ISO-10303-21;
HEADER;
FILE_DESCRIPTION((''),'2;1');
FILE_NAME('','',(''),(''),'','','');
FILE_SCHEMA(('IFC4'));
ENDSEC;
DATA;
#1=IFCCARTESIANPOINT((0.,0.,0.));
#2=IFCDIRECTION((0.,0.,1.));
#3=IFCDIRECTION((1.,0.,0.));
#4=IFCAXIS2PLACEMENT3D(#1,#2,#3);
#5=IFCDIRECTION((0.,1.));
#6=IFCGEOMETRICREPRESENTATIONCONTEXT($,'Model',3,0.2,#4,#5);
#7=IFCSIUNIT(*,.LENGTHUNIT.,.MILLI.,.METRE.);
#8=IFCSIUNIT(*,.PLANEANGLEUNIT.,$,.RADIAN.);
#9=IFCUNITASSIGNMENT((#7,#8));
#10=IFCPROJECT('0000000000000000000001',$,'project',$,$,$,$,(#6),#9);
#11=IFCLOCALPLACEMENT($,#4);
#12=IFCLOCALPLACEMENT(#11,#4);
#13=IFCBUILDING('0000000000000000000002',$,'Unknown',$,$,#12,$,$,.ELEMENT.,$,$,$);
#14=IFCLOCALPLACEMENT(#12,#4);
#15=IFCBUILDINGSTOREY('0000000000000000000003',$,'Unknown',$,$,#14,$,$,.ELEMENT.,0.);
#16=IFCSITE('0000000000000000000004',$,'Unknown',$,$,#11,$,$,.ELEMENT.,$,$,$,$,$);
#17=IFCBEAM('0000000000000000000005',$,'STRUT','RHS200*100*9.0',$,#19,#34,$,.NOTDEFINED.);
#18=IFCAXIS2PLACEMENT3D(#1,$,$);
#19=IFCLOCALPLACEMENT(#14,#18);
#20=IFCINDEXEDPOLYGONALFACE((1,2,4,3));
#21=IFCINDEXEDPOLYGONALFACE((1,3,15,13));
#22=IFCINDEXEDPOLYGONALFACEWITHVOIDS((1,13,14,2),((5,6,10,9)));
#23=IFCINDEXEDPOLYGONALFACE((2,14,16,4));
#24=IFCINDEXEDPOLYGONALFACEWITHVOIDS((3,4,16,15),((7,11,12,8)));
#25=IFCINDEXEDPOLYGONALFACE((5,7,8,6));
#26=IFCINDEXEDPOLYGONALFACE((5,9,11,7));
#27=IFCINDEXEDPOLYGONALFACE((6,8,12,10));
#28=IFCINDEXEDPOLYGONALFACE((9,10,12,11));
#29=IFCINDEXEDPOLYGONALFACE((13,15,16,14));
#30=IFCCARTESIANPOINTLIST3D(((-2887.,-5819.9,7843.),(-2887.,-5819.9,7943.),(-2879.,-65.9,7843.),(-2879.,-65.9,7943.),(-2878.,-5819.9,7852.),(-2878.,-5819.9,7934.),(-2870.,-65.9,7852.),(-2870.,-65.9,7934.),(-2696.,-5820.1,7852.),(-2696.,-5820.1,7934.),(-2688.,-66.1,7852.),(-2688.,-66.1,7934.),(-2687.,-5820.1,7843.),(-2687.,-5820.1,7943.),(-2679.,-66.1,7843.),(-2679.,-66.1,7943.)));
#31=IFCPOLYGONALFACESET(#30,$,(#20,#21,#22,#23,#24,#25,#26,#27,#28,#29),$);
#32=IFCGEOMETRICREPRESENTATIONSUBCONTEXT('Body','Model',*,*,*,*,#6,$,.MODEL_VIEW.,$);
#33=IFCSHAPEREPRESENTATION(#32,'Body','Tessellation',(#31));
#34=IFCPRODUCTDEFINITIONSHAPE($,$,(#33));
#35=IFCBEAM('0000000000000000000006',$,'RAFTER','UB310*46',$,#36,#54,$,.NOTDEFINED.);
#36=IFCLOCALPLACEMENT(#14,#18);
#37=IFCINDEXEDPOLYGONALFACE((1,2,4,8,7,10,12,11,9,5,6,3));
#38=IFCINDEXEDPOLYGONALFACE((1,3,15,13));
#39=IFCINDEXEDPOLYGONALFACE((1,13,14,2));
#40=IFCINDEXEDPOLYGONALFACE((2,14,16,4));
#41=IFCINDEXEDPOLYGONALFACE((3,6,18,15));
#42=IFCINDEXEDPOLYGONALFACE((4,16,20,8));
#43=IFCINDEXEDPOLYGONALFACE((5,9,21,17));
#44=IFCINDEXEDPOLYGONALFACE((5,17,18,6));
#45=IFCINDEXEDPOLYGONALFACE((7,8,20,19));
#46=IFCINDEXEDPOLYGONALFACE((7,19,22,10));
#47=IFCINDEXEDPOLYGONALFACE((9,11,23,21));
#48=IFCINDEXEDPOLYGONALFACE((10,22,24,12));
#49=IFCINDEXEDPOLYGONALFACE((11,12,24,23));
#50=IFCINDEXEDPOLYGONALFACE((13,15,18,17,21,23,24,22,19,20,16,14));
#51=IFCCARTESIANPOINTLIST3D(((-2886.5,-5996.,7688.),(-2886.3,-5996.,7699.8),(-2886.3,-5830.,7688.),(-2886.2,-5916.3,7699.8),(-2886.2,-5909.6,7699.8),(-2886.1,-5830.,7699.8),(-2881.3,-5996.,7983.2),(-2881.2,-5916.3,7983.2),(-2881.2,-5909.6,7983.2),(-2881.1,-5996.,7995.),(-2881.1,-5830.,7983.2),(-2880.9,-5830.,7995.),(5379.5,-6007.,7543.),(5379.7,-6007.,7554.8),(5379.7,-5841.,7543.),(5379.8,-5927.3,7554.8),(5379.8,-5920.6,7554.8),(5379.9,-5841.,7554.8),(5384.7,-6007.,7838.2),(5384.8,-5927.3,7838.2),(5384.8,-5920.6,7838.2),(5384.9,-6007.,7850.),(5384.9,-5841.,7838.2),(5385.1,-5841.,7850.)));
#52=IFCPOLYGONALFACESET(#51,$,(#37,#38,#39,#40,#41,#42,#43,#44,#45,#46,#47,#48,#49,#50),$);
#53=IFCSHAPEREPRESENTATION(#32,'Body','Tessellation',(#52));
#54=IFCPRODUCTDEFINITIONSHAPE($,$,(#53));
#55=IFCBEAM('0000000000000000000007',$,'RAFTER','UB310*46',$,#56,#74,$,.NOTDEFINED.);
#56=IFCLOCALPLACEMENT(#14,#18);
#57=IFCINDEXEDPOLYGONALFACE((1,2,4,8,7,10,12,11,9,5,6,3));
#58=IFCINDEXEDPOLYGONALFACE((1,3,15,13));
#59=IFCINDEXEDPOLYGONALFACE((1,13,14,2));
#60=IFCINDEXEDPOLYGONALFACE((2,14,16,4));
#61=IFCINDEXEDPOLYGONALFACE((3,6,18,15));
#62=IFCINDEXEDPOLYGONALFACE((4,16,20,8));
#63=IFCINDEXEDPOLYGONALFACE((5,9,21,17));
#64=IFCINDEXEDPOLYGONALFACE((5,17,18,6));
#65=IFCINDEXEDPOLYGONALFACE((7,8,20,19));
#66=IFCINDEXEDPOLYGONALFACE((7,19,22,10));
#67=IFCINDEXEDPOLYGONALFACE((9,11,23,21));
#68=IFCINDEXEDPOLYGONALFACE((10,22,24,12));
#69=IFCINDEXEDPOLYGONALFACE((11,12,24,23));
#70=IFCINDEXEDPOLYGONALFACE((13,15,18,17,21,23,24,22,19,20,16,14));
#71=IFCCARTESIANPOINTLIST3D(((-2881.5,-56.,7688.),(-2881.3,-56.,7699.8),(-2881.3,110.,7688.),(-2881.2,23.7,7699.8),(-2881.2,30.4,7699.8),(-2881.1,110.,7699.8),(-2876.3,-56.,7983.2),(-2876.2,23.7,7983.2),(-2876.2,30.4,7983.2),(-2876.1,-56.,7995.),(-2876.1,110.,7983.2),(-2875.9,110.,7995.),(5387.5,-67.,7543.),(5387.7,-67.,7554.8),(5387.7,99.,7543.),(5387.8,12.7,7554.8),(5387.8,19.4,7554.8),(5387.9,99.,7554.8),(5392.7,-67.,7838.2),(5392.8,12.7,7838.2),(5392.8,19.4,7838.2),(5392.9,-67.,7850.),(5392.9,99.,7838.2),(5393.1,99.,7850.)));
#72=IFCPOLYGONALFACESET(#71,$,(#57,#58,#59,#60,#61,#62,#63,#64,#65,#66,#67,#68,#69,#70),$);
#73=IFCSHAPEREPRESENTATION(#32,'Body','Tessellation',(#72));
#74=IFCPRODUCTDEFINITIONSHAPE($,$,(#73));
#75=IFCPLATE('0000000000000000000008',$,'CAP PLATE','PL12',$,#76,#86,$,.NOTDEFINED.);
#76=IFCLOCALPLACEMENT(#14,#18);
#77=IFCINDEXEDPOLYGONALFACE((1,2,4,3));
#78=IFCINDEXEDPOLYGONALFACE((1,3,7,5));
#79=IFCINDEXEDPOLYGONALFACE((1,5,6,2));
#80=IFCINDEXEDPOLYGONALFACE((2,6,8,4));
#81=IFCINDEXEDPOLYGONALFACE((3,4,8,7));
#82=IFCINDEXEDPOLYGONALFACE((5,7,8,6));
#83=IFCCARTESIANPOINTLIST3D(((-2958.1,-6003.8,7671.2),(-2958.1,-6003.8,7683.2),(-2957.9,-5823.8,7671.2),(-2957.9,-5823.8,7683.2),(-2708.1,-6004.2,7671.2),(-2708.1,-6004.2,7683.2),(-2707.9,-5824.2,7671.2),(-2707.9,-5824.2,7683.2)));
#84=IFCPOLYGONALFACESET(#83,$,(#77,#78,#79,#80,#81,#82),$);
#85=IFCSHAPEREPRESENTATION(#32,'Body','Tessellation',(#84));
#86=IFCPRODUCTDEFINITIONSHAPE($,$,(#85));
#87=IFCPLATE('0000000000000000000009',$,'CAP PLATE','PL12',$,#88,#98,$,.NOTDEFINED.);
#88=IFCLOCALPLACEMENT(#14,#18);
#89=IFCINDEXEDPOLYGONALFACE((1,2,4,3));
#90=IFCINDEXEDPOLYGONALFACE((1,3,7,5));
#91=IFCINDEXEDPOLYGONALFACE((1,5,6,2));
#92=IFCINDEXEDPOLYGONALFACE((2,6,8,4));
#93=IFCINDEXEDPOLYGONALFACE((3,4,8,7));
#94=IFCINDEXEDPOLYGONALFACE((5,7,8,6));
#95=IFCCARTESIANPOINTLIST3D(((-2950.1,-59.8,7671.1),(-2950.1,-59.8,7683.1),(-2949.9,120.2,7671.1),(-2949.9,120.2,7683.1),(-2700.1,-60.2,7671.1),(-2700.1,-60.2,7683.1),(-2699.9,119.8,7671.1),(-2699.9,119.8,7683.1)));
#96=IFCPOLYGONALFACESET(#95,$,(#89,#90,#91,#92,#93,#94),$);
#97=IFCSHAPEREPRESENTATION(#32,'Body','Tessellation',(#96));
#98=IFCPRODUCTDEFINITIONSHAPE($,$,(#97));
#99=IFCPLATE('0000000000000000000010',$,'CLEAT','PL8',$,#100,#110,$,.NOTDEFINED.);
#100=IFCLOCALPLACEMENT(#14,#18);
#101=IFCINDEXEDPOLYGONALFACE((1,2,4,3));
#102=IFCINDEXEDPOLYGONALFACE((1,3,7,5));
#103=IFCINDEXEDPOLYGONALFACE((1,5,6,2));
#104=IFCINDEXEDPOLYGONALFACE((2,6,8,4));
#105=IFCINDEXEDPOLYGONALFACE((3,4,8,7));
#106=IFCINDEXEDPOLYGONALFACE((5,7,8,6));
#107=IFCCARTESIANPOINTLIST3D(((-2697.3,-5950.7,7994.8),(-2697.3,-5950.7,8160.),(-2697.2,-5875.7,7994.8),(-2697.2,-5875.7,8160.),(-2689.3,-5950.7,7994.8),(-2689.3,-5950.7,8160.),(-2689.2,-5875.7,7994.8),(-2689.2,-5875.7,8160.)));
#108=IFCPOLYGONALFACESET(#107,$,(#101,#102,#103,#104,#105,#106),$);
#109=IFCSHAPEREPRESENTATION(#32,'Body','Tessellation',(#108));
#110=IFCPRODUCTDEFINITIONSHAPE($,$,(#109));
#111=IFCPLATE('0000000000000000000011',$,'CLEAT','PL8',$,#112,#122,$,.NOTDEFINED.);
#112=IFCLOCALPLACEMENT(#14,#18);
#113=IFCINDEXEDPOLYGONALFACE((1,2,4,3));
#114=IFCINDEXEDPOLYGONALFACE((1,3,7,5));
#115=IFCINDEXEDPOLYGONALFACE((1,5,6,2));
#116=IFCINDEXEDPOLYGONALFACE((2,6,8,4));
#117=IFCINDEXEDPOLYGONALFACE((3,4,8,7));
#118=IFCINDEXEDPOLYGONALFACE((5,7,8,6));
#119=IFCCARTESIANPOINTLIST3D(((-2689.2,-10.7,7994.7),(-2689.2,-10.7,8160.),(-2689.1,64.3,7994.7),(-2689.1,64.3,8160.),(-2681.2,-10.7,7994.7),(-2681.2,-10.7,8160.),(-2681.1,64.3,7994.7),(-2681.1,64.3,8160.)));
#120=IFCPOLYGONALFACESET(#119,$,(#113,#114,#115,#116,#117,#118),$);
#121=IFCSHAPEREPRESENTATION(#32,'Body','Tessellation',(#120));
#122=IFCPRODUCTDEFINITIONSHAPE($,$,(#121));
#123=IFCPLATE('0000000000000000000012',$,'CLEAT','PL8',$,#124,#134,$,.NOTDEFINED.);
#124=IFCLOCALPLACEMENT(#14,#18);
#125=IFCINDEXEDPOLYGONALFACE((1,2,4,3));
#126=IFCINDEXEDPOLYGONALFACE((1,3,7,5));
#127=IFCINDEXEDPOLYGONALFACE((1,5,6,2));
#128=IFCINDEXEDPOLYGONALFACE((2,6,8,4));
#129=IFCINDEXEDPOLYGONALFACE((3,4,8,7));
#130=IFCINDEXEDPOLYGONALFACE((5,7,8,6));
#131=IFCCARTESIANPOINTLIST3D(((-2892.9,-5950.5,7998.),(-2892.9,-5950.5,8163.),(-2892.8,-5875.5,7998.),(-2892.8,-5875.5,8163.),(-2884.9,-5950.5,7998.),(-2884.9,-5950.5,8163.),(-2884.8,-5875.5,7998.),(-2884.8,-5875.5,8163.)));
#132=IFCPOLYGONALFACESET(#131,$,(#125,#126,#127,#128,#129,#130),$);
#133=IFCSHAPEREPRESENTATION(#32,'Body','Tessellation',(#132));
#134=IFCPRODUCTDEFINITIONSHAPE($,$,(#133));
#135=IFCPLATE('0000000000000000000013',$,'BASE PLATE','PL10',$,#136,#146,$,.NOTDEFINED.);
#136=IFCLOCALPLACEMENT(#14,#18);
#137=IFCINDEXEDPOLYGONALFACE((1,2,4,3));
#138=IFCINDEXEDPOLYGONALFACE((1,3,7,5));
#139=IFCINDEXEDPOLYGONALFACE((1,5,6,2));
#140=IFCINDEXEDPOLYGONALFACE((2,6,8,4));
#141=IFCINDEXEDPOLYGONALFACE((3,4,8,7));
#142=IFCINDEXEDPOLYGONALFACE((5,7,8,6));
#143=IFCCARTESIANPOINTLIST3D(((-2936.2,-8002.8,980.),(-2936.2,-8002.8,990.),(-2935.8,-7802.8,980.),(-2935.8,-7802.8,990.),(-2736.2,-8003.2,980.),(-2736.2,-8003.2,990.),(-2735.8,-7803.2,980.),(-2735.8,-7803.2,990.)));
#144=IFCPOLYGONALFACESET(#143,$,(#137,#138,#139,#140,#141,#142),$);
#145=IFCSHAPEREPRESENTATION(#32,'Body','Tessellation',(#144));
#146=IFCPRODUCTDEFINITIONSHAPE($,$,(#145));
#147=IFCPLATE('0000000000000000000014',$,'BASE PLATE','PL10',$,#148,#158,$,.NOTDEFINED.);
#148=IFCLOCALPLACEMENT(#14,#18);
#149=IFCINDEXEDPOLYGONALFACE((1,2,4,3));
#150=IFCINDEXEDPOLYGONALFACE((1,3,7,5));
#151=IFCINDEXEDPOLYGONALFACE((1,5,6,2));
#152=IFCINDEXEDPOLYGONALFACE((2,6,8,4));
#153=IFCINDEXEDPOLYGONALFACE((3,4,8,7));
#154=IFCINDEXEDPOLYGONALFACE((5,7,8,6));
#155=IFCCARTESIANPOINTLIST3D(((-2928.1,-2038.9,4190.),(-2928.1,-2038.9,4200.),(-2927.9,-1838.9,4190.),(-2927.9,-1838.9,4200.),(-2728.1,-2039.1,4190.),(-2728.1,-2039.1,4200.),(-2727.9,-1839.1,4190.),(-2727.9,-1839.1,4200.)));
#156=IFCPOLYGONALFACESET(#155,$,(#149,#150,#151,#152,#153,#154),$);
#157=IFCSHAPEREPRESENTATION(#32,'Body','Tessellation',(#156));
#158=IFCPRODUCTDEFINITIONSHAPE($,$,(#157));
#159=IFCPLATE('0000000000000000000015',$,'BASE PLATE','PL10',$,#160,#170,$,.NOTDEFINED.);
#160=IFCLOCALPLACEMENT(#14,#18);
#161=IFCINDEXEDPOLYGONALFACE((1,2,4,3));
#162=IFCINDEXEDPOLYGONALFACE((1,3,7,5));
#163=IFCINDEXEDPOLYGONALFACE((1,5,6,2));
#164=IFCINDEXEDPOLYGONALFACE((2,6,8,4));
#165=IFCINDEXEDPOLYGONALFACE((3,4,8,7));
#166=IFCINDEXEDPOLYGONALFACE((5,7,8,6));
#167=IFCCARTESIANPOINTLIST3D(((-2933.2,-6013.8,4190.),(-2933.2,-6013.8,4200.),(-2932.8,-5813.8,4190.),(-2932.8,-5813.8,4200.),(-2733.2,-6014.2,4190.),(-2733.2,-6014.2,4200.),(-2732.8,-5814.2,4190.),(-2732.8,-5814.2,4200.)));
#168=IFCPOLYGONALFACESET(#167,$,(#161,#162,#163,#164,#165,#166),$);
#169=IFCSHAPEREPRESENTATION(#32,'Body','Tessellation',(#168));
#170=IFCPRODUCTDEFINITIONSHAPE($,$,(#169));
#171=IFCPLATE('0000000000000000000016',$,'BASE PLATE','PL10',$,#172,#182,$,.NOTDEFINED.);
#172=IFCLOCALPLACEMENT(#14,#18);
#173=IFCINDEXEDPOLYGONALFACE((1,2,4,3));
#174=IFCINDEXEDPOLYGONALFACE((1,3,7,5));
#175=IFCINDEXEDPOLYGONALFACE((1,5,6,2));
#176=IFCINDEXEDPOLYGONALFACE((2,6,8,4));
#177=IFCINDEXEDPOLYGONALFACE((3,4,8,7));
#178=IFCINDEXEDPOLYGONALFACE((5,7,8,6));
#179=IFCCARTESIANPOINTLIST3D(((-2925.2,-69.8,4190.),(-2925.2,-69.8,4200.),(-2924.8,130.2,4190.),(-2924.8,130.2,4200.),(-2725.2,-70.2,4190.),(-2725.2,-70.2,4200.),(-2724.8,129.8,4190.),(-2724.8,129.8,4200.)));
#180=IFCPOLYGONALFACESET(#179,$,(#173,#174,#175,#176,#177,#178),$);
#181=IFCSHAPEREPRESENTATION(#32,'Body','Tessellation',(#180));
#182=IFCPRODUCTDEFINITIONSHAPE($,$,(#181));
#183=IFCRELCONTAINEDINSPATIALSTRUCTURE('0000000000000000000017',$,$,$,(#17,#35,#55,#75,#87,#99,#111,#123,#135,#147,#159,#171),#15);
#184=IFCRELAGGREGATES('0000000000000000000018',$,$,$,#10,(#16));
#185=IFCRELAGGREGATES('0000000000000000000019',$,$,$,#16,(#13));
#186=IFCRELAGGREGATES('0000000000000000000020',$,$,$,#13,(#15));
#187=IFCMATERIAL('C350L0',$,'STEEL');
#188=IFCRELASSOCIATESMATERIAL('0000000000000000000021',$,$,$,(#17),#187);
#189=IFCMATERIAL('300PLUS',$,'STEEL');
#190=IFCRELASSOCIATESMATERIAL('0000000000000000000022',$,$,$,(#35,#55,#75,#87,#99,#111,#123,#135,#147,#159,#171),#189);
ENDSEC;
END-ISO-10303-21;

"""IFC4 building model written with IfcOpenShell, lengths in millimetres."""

from ifc_helpers import new_model, si_unit, direction, frame, origin_with_axes, place, context, subcontext, project, spatial, line, indexed_curve, outline, extrude, material, element, save


model = new_model("IFC4")

# Units and contexts
model_context = context("Model", 3, precision=0.2, world=origin_with_axes(), true_north=direction((0.0, 1.0)))
body_context = subcontext(model_context, "Body", "Model", "MODEL_VIEW")
ifc_project = project(units=[si_unit("LENGTHUNIT", "METRE", prefix="MILLI"), si_unit("PLANEANGLEUNIT", "RADIAN")], contexts=[model_context])

# Site, building, storey
site_placement = place(None, origin_with_axes())
site = spatial("IfcSite", under=ifc_project, at=site_placement, Name="Unknown", CompositionType="ELEMENT")
building_placement = place(site_placement, origin_with_axes())
building = spatial("IfcBuilding", under=site, at=building_placement, Name="Unknown", CompositionType="ELEMENT")
storey_placement = place(building_placement, origin_with_axes())
storey = spatial("IfcBuildingStorey", under=building, at=storey_placement, Name="Unknown", CompositionType="ELEMENT", Elevation=0.0)

# Shared definitions
ifc_material_1 = material(Name="C350L0", Category="STEEL")

# Beams
beam_1_placement = place(storey_placement, frame((-2779.0, -66.0, 7893.0), z_axis=(0.0, 0.0, 1.0), x_axis=(-0.00139, -0.999999, 0.0)))
element("IfcBeam", 1, at=beam_1_placement, inside=storey, material=ifc_material_1, Name="STRUT", Description="RHS200*100*9.0", PredefinedType="NOTDEFINED", context=body_context, shape_type="SolidModel", body=[
    extrude(outline(indexed_curve([(-50.0, -100.0), (50.0, -100.0), (50.0, 100.0), (-50.0, 100.0)], segments=[line(1, 2, 3, 4, 1)]), holes=[indexed_curve([(-41.0, -91.0), (-41.0, 91.0), (41.0, 91.0), (41.0, -91.0)], segments=[line(1, 2, 3, 4, 1)])]), frame((0.0, 0.0, 0.0), z_axis=(-1.0, 0.0, 0.0), x_axis=(0.0, 0.0, 1.0)), (0.0, 0.0, -1.0), 5754.0),
])
ifc_material_2 = material(Name="300PLUS", Category="STEEL")
beam_2_placement = place(storey_placement, frame((-2883.7, -5913.0, 7841.5), z_axis=(-0.001331, -0.999999, 0.0), x_axis=(0.999845, -0.001331, -0.017539)))
element("IfcBeam", 2, at=beam_2_placement, inside=storey, material=ifc_material_2, Name="RAFTER", Description="UB310*46", PredefinedType="NOTDEFINED", context=body_context, shape_type="SolidModel", body=[
    extrude(outline(indexed_curve([(-83.0, -153.5), (83.0, -153.5), (83.0, -141.7), (3.4, -141.7), (3.4, 141.7), (83.0, 141.7), (83.0, 153.5), (-83.0, 153.5), (-83.0, 141.7), (-3.4, 141.7), (-3.4, -141.7), (-83.0, -141.7)], segments=[line(1, 2, 3, 4, 5, 6, 7, 8, 9, 10, 11, 12, 1)])), frame((0.0, 0.0, 0.0), z_axis=(-1.0, 0.0, 0.0), x_axis=(0.0, 0.0, 1.0)), (0.0, 0.0, -1.0), 8267.3),
])
beam_3_placement = place(storey_placement, frame((-2878.7, 27.0, 7841.5), z_axis=(-0.00133, -0.999999, 0.0), x_axis=(0.999845, -0.00133, -0.017533)))
element("IfcBeam", 3, at=beam_3_placement, inside=storey, material=ifc_material_2, Name="RAFTER", Description="UB310*46", PredefinedType="NOTDEFINED", context=body_context, shape_type="SolidModel", body=[
    extrude(outline(indexed_curve([(-83.0, -153.5), (83.0, -153.5), (83.0, -141.7), (3.4, -141.7), (3.4, 141.7), (83.0, 141.7), (83.0, 153.5), (-83.0, 153.5), (-83.0, 141.7), (-3.4, 141.7), (-3.4, -141.7), (-83.0, -141.7)], segments=[line(1, 2, 3, 4, 5, 6, 7, 8, 9, 10, 11, 12, 1)])), frame((0.0, 0.0, 0.0), z_axis=(-1.0, 0.0, 0.0), x_axis=(0.0, 0.0, 1.0)), (0.0, 0.0, -1.0), 8270.3),
])

# Plates
for number, where, z_axis, x_axis, name in (
    (4, (-2958.1, -6003.8, 7677.2), (0.0, 0.0, 1.0), (0.999999, -0.0016, 0.0), "CAP PLATE"),
    (5, (-2950.1, -59.8, 7677.1), (0.0, 0.0, 1.0), (0.999999, -0.0016, 0.0), "CAP PLATE"),
):
    element("IfcPlate", number, at=place(storey_placement, frame(where, z_axis=z_axis, x_axis=x_axis)), inside=storey, material=ifc_material_2, Name=name, Description="PL12", PredefinedType="NOTDEFINED", context=body_context, shape_type="SolidModel", body=[
        extrude(outline(indexed_curve([(0.0, 0.0), (250.0, 0.0), (249.9, 180.0), (-0.1, 180.0)], segments=[line(1, 2, 3, 4, 1)])), frame((0.0, 0.0, 6.0), z_axis=(0.0, 0.0, 1.0), x_axis=(1.0, 0.0, 0.0)), (0.0, 0.0, -1.0), 12.0),
    ])
plate_1_placement = place(storey_placement, frame((-2693.2, -5875.7, 8160.0), z_axis=(0.999999, -0.001333, 0.0), x_axis=(-0.001333, -0.999999, 0.0)))
element("IfcPlate", 6, at=plate_1_placement, inside=storey, material=ifc_material_2, Name="CLEAT", Description="PL8", PredefinedType="NOTDEFINED", context=body_context, shape_type="SolidModel", body=[
    extrude(outline(indexed_curve([(0.0, 0.0), (75.0, 0.0), (75.0, 165.2), (0.0, 165.2)], segments=[line(1, 2, 3, 4, 1)])), frame((0.0, 0.0, 4.0), z_axis=(0.0, 0.0, 1.0), x_axis=(1.0, 0.0, 0.0)), (0.0, 0.0, -1.0), 8.0),
])
plate_2_placement = place(storey_placement, frame((-2685.1, 64.3, 8160.0), z_axis=(0.999999, -0.001333, 0.0), x_axis=(-0.001333, -0.999999, 0.0)))
element("IfcPlate", 7, at=plate_2_placement, inside=storey, material=ifc_material_2, Name="CLEAT", Description="PL8", PredefinedType="NOTDEFINED", context=body_context, shape_type="SolidModel", body=[
    extrude(outline(indexed_curve([(0.0, 0.0), (75.0, 0.0), (75.0, 165.3), (0.0, 165.3)], segments=[line(1, 2, 3, 4, 1)])), frame((0.0, 0.0, 4.0), z_axis=(0.0, 0.0, 1.0), x_axis=(1.0, 0.0, 0.0)), (0.0, 0.0, -1.0), 8.0),
])
plate_3_placement = place(storey_placement, frame((-2888.8, -5875.5, 8163.0), z_axis=(0.999999, -0.001333, 0.0), x_axis=(-0.001333, -0.999999, 0.0)))
element("IfcPlate", 8, at=plate_3_placement, inside=storey, material=ifc_material_2, Name="CLEAT", Description="PL8", PredefinedType="NOTDEFINED", context=body_context, shape_type="SolidModel", body=[
    extrude(outline(indexed_curve([(0.0, 0.0), (75.0, 0.0), (75.0, 165.0), (0.0, 165.0)], segments=[line(1, 2, 3, 4, 1)])), frame((0.0, 0.0, 4.0), z_axis=(0.0, 0.0, 1.0), x_axis=(1.0, 0.0, 0.0)), (0.0, 0.0, -1.0), 8.0),
])
plate_4_placement = place(storey_placement, frame((-2935.8, -7802.8, 985.0), z_axis=(0.0, 0.0, 1.0), x_axis=(-0.002, -0.999998, 0.0)))
element("IfcPlate", 9, at=plate_4_placement, inside=storey, material=ifc_material_2, Name="BASE PLATE", Description="PL10", PredefinedType="NOTDEFINED", context=body_context, shape_type="SolidModel", body=[
    extrude(outline(indexed_curve([(0.0, 0.0), (200.0, 0.0), (200.0, 200.0), (0.0, 200.0)], segments=[line(1, 2, 3, 4, 1)])), frame((0.0, 0.0, 5.0), z_axis=(0.0, 0.0, 1.0), x_axis=(1.0, 0.0, 0.0)), (0.0, 0.0, -1.0), 10.0),
])
plate_5_placement = place(storey_placement, frame((-2927.9, -1838.9, 4195.0), z_axis=(0.0, 0.0, 1.0), x_axis=(-0.001, -1.0, 0.0)))
element("IfcPlate", 10, at=plate_5_placement, inside=storey, material=ifc_material_2, Name="BASE PLATE", Description="PL10", PredefinedType="NOTDEFINED", context=body_context, shape_type="SolidModel", body=[
    extrude(outline(indexed_curve([(0.0, 0.0), (200.0, 0.0), (200.0, 200.0), (0.0, 200.0)], segments=[line(1, 2, 3, 4, 1)])), frame((0.0, 0.0, 5.0), z_axis=(0.0, 0.0, 1.0), x_axis=(1.0, 0.0, 0.0)), (0.0, 0.0, -1.0), 10.0),
])
for number, where, z_axis, x_axis, name in (
    (11, (-2932.8, -5813.8, 4195.0), (0.0, 0.0, 1.0), (-0.002, -0.999998, 0.0), "BASE PLATE"),
    (12, (-2924.8, 130.2, 4195.0), (0.0, 0.0, 1.0), (-0.002, -0.999998, 0.0), "BASE PLATE"),
):
    element("IfcPlate", number, at=place(storey_placement, frame(where, z_axis=z_axis, x_axis=x_axis)), inside=storey, material=ifc_material_2, Name=name, Description="PL10", PredefinedType="NOTDEFINED", context=body_context, shape_type="SolidModel", body=[
        extrude(outline(indexed_curve([(0.0, 0.0), (200.0, 0.0), (200.0, 200.0), (0.0, 200.0)], segments=[line(1, 2, 3, 4, 1)])), frame((0.0, 0.0, 5.0), z_axis=(0.0, 0.0, 1.0), x_axis=(1.0, 0.0, 0.0)), (0.0, 0.0, -1.0), 10.0),
    ])

save(model, "model.ifc")
